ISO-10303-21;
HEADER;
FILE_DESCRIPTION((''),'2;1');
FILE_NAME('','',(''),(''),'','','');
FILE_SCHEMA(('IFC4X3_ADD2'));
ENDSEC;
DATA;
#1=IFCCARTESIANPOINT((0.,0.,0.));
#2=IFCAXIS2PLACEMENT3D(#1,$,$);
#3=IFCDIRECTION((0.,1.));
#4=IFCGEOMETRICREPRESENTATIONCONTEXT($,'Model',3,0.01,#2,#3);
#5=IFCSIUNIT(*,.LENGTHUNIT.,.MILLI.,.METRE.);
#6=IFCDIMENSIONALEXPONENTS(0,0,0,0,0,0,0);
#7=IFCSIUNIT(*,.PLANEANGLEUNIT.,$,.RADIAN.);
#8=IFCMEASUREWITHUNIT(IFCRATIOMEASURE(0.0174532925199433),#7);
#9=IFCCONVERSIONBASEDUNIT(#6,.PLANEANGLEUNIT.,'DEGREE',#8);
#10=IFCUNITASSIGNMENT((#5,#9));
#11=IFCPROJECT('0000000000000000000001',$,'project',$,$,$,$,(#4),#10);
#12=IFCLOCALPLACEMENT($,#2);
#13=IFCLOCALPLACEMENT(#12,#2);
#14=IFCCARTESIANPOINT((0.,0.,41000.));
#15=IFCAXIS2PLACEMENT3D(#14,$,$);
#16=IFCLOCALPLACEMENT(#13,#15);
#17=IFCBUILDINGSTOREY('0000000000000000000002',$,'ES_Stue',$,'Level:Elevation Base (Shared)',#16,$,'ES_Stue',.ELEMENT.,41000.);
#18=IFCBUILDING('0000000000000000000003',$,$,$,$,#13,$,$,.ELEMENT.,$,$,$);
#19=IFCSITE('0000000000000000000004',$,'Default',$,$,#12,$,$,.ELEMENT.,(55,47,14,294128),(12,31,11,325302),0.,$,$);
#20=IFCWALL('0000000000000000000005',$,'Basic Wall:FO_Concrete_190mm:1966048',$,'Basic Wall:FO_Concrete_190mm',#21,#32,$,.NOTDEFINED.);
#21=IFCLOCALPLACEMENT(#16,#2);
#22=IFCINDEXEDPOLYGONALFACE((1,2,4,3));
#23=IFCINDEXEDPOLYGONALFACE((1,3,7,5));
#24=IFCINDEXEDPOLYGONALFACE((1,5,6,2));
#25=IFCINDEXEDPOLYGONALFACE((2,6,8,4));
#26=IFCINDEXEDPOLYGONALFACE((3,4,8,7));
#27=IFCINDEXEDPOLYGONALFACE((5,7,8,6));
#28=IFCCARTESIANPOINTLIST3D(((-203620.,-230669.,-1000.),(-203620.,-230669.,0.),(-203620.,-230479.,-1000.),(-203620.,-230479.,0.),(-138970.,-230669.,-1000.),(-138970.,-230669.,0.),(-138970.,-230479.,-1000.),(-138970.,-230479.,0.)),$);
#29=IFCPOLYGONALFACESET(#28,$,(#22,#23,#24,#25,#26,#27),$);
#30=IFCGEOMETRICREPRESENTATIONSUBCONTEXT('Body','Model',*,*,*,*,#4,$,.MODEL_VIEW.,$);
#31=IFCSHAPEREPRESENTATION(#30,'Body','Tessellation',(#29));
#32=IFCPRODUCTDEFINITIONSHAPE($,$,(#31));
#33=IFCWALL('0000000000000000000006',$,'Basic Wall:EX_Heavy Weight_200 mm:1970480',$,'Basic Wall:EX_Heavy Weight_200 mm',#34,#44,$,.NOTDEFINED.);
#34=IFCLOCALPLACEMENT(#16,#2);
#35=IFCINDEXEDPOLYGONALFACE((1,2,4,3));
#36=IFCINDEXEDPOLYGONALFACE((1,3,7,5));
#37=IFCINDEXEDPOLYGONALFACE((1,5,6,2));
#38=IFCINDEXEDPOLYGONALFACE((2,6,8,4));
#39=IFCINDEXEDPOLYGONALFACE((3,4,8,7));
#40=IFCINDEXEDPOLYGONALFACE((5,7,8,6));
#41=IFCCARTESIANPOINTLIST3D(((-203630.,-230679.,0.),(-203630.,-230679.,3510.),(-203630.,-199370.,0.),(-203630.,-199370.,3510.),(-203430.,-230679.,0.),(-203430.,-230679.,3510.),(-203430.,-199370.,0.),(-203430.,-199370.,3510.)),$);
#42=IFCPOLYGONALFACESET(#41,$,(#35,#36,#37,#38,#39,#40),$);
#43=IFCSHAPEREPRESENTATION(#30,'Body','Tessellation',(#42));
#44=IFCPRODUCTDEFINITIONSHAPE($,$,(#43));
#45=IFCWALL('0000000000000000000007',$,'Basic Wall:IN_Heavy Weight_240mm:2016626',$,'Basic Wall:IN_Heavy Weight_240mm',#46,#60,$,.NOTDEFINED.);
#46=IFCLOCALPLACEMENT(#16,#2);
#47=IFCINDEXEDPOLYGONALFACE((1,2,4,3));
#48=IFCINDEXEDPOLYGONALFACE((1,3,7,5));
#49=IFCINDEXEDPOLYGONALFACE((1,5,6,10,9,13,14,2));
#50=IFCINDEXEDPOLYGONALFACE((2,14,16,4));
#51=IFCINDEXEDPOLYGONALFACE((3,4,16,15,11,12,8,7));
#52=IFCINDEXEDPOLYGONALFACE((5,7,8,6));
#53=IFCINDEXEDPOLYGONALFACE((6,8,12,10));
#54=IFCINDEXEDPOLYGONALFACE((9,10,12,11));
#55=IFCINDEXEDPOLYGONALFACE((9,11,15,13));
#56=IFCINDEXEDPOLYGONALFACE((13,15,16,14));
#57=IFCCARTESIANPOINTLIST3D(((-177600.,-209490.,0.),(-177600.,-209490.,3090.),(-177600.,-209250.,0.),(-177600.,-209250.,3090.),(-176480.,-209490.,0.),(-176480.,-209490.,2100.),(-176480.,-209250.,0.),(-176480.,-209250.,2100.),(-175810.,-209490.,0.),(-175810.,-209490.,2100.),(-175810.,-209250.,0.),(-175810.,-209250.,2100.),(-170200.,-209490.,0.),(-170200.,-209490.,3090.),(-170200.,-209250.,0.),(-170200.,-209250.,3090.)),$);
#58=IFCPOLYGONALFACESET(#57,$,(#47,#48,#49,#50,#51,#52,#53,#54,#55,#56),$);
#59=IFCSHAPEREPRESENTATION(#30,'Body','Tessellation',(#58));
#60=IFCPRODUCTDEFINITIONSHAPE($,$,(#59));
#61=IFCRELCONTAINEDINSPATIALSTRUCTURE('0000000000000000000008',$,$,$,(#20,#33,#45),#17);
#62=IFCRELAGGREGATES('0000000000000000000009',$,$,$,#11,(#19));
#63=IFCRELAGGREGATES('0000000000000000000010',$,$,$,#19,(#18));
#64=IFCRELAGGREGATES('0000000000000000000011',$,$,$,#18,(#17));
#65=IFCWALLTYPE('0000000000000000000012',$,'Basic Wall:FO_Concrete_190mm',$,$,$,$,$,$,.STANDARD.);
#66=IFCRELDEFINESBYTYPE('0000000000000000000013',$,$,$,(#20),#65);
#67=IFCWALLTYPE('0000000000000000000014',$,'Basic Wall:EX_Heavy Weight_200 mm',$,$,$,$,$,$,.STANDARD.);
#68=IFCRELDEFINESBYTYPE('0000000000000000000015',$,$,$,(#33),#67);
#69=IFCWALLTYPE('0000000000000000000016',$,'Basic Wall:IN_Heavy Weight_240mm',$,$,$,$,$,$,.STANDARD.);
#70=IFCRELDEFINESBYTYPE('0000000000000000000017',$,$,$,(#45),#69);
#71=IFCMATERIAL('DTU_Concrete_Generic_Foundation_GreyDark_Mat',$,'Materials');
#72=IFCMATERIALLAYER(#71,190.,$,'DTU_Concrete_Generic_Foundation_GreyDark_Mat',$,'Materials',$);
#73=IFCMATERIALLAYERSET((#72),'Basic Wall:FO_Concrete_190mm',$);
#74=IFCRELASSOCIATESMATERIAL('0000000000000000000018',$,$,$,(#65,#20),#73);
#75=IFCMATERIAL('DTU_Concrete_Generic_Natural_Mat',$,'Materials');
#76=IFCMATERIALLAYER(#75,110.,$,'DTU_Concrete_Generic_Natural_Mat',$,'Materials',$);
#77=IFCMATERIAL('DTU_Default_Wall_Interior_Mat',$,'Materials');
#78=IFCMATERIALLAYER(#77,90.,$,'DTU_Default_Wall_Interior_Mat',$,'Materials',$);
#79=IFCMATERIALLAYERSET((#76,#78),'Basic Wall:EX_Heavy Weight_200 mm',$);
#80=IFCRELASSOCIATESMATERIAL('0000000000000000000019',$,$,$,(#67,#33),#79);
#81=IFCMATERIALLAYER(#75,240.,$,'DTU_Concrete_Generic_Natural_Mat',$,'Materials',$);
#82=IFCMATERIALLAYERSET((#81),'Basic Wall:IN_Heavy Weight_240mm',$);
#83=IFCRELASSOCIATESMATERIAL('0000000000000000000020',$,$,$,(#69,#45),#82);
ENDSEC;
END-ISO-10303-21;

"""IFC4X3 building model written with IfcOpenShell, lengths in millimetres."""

from ifc_helpers import new_model, entity, si_unit, converted_unit, direction, frame, frame_2d, origin, place, context, subcontext, project, spatial, rectangle, extrude, material, layer, layer_set, type_object, element, save


model = new_model("IFC4X3")

# Units and contexts
model_context = context("Model", 3, precision=0.01, world=origin(), true_north=direction((0.0, 1.0)))
body_context = subcontext(model_context, "Body", "Model", "MODEL_VIEW")
ifc_project = project(units=[si_unit("LENGTHUNIT", "METRE", prefix="MILLI"), converted_unit("PLANEANGLEUNIT", "DEGREE", entity("IfcRatioMeasure", 0.0174532925199433), si_unit("PLANEANGLEUNIT", "RADIAN"), dimensions=[0, 0, 0, 0, 0, 0, 0])], contexts=[model_context])

# Site, building, storey
site_placement = place(None, origin())
site = spatial("IfcSite", under=ifc_project, at=site_placement, Name="Default", CompositionType="ELEMENT", RefLatitude=(55, 47, 14, 294128), RefLongitude=(12, 31, 11, 325302), RefElevation=0.0)
building_placement = place(site_placement, origin())
building = spatial("IfcBuilding", under=site, at=building_placement, CompositionType="ELEMENT")
storey_placement = place(building_placement, frame((0.0, 0.0, 41000.0)))
storey = spatial("IfcBuildingStorey", under=building, at=storey_placement, Name="ES_Stue", ObjectType="Level:Elevation Base (Shared)", LongName="ES_Stue", CompositionType="ELEMENT", Elevation=41000.0)

# Shared definitions
ifc_material_1 = material(Name="DTU_Concrete_Generic_Natural_Mat", Category="Materials")

# Shared definitions
ifc_material_2 = material(Name="DTU_Default_Wall_Interior_Mat", Category="Materials")

# Walls
ifc_material_3 = material(Name="DTU_Concrete_Generic_Foundation_GreyDark_Mat", Category="Materials")
ifc_layer_1 = layer(ifc_material_3, 190.0, Name="DTU_Concrete_Generic_Foundation_GreyDark_Mat", Category="Materials")
ifc_layer_set_1 = layer_set([ifc_layer_1], Name="Basic Wall:FO_Concrete_190mm")
wall_type_1 = type_object("IfcWallType", Name="Basic Wall:FO_Concrete_190mm", PredefinedType="STANDARD", material=ifc_layer_set_1)
wall_1_placement = place(storey_placement, frame((-203620.0, -230574.0, -1000.0)))
element("IfcWall", 1, at=wall_1_placement, inside=storey, type_object=wall_type_1, material=ifc_layer_set_1, Name="Basic Wall:FO_Concrete_190mm:1966048", ObjectType="Basic Wall:FO_Concrete_190mm", PredefinedType="NOTDEFINED", context=body_context, shape_type="SweptSolid", body=[
    extrude(rectangle(XDim=64650.0, YDim=190.0, at=frame_2d((32325.0, 0.0), x_axis=(-1.0, 0.0))), origin(), (0.0, 0.0, 1.0), 1000.0),
])
ifc_layer_2 = layer(ifc_material_1, 110.0, Name="DTU_Concrete_Generic_Natural_Mat", Category="Materials")
ifc_layer_3 = layer(ifc_material_2, 90.0, Name="DTU_Default_Wall_Interior_Mat", Category="Materials")
ifc_layer_set_2 = layer_set([ifc_layer_2, ifc_layer_3], Name="Basic Wall:EX_Heavy Weight_200 mm")
wall_type_2 = type_object("IfcWallType", Name="Basic Wall:EX_Heavy Weight_200 mm", PredefinedType="STANDARD", material=ifc_layer_set_2)
wall_2_placement = place(storey_placement, frame((-203530.0, -230679.0, 0.0), z_axis=(0.0, 0.0, 1.0), x_axis=(0.0, 1.0, 0.0)))
element("IfcWall", 2, at=wall_2_placement, inside=storey, type_object=wall_type_2, material=ifc_layer_set_2, Name="Basic Wall:EX_Heavy Weight_200 mm:1970480", ObjectType="Basic Wall:EX_Heavy Weight_200 mm", PredefinedType="NOTDEFINED", context=body_context, shape_type="SweptSolid", body=[
    extrude(rectangle(XDim=31309.0, YDim=200.0, at=frame_2d((15654.5, 0.0), x_axis=(-1.0, 0.0))), origin(), (0.0, 0.0, 1.0), 3510.0),
])

# Wall, opening
ifc_layer_4 = layer(ifc_material_1, 240.0, Name="DTU_Concrete_Generic_Natural_Mat", Category="Materials")
ifc_layer_set_3 = layer_set([ifc_layer_4], Name="Basic Wall:IN_Heavy Weight_240mm")
wall_type_3 = type_object("IfcWallType", Name="Basic Wall:IN_Heavy Weight_240mm", PredefinedType="STANDARD", material=ifc_layer_set_3)
wall_3_placement = place(storey_placement, frame((-177600.0, -209370.0, 0.0)))
wall_3 = element("IfcWall", 3, at=wall_3_placement, inside=storey, type_object=wall_type_3, material=ifc_layer_set_3, Name="Basic Wall:IN_Heavy Weight_240mm:2016626", ObjectType="Basic Wall:IN_Heavy Weight_240mm", PredefinedType="NOTDEFINED", context=body_context, shape_type="SweptSolid", body=[
    extrude(rectangle(XDim=7400.0, YDim=240.0, at=frame_2d((3700.0, 0.0), x_axis=(-1.0, 0.0))), origin(), (0.0, 0.0, 1.0), 3090.0),
])
opening_1_placement = place(wall_3_placement, frame((1120.0, -120.0, 0.0)))
element("IfcOpeningElement", 4, at=opening_1_placement, cuts=wall_3, PredefinedType="OPENING", context=body_context, shape_type="SweptSolid", body=[
    extrude(rectangle(XDim=2100.0, YDim=670.0, at=frame_2d((1050.0, 335.0), x_axis=(1.0, 0.0))), frame((0.0, 0.0, 0.0), z_axis=(0.0, 1.0, 0.0), x_axis=(0.0, 0.0, 1.0)), (0.0, 0.0, 1.0), 240.0),
])

save(model, "model.ifc")
